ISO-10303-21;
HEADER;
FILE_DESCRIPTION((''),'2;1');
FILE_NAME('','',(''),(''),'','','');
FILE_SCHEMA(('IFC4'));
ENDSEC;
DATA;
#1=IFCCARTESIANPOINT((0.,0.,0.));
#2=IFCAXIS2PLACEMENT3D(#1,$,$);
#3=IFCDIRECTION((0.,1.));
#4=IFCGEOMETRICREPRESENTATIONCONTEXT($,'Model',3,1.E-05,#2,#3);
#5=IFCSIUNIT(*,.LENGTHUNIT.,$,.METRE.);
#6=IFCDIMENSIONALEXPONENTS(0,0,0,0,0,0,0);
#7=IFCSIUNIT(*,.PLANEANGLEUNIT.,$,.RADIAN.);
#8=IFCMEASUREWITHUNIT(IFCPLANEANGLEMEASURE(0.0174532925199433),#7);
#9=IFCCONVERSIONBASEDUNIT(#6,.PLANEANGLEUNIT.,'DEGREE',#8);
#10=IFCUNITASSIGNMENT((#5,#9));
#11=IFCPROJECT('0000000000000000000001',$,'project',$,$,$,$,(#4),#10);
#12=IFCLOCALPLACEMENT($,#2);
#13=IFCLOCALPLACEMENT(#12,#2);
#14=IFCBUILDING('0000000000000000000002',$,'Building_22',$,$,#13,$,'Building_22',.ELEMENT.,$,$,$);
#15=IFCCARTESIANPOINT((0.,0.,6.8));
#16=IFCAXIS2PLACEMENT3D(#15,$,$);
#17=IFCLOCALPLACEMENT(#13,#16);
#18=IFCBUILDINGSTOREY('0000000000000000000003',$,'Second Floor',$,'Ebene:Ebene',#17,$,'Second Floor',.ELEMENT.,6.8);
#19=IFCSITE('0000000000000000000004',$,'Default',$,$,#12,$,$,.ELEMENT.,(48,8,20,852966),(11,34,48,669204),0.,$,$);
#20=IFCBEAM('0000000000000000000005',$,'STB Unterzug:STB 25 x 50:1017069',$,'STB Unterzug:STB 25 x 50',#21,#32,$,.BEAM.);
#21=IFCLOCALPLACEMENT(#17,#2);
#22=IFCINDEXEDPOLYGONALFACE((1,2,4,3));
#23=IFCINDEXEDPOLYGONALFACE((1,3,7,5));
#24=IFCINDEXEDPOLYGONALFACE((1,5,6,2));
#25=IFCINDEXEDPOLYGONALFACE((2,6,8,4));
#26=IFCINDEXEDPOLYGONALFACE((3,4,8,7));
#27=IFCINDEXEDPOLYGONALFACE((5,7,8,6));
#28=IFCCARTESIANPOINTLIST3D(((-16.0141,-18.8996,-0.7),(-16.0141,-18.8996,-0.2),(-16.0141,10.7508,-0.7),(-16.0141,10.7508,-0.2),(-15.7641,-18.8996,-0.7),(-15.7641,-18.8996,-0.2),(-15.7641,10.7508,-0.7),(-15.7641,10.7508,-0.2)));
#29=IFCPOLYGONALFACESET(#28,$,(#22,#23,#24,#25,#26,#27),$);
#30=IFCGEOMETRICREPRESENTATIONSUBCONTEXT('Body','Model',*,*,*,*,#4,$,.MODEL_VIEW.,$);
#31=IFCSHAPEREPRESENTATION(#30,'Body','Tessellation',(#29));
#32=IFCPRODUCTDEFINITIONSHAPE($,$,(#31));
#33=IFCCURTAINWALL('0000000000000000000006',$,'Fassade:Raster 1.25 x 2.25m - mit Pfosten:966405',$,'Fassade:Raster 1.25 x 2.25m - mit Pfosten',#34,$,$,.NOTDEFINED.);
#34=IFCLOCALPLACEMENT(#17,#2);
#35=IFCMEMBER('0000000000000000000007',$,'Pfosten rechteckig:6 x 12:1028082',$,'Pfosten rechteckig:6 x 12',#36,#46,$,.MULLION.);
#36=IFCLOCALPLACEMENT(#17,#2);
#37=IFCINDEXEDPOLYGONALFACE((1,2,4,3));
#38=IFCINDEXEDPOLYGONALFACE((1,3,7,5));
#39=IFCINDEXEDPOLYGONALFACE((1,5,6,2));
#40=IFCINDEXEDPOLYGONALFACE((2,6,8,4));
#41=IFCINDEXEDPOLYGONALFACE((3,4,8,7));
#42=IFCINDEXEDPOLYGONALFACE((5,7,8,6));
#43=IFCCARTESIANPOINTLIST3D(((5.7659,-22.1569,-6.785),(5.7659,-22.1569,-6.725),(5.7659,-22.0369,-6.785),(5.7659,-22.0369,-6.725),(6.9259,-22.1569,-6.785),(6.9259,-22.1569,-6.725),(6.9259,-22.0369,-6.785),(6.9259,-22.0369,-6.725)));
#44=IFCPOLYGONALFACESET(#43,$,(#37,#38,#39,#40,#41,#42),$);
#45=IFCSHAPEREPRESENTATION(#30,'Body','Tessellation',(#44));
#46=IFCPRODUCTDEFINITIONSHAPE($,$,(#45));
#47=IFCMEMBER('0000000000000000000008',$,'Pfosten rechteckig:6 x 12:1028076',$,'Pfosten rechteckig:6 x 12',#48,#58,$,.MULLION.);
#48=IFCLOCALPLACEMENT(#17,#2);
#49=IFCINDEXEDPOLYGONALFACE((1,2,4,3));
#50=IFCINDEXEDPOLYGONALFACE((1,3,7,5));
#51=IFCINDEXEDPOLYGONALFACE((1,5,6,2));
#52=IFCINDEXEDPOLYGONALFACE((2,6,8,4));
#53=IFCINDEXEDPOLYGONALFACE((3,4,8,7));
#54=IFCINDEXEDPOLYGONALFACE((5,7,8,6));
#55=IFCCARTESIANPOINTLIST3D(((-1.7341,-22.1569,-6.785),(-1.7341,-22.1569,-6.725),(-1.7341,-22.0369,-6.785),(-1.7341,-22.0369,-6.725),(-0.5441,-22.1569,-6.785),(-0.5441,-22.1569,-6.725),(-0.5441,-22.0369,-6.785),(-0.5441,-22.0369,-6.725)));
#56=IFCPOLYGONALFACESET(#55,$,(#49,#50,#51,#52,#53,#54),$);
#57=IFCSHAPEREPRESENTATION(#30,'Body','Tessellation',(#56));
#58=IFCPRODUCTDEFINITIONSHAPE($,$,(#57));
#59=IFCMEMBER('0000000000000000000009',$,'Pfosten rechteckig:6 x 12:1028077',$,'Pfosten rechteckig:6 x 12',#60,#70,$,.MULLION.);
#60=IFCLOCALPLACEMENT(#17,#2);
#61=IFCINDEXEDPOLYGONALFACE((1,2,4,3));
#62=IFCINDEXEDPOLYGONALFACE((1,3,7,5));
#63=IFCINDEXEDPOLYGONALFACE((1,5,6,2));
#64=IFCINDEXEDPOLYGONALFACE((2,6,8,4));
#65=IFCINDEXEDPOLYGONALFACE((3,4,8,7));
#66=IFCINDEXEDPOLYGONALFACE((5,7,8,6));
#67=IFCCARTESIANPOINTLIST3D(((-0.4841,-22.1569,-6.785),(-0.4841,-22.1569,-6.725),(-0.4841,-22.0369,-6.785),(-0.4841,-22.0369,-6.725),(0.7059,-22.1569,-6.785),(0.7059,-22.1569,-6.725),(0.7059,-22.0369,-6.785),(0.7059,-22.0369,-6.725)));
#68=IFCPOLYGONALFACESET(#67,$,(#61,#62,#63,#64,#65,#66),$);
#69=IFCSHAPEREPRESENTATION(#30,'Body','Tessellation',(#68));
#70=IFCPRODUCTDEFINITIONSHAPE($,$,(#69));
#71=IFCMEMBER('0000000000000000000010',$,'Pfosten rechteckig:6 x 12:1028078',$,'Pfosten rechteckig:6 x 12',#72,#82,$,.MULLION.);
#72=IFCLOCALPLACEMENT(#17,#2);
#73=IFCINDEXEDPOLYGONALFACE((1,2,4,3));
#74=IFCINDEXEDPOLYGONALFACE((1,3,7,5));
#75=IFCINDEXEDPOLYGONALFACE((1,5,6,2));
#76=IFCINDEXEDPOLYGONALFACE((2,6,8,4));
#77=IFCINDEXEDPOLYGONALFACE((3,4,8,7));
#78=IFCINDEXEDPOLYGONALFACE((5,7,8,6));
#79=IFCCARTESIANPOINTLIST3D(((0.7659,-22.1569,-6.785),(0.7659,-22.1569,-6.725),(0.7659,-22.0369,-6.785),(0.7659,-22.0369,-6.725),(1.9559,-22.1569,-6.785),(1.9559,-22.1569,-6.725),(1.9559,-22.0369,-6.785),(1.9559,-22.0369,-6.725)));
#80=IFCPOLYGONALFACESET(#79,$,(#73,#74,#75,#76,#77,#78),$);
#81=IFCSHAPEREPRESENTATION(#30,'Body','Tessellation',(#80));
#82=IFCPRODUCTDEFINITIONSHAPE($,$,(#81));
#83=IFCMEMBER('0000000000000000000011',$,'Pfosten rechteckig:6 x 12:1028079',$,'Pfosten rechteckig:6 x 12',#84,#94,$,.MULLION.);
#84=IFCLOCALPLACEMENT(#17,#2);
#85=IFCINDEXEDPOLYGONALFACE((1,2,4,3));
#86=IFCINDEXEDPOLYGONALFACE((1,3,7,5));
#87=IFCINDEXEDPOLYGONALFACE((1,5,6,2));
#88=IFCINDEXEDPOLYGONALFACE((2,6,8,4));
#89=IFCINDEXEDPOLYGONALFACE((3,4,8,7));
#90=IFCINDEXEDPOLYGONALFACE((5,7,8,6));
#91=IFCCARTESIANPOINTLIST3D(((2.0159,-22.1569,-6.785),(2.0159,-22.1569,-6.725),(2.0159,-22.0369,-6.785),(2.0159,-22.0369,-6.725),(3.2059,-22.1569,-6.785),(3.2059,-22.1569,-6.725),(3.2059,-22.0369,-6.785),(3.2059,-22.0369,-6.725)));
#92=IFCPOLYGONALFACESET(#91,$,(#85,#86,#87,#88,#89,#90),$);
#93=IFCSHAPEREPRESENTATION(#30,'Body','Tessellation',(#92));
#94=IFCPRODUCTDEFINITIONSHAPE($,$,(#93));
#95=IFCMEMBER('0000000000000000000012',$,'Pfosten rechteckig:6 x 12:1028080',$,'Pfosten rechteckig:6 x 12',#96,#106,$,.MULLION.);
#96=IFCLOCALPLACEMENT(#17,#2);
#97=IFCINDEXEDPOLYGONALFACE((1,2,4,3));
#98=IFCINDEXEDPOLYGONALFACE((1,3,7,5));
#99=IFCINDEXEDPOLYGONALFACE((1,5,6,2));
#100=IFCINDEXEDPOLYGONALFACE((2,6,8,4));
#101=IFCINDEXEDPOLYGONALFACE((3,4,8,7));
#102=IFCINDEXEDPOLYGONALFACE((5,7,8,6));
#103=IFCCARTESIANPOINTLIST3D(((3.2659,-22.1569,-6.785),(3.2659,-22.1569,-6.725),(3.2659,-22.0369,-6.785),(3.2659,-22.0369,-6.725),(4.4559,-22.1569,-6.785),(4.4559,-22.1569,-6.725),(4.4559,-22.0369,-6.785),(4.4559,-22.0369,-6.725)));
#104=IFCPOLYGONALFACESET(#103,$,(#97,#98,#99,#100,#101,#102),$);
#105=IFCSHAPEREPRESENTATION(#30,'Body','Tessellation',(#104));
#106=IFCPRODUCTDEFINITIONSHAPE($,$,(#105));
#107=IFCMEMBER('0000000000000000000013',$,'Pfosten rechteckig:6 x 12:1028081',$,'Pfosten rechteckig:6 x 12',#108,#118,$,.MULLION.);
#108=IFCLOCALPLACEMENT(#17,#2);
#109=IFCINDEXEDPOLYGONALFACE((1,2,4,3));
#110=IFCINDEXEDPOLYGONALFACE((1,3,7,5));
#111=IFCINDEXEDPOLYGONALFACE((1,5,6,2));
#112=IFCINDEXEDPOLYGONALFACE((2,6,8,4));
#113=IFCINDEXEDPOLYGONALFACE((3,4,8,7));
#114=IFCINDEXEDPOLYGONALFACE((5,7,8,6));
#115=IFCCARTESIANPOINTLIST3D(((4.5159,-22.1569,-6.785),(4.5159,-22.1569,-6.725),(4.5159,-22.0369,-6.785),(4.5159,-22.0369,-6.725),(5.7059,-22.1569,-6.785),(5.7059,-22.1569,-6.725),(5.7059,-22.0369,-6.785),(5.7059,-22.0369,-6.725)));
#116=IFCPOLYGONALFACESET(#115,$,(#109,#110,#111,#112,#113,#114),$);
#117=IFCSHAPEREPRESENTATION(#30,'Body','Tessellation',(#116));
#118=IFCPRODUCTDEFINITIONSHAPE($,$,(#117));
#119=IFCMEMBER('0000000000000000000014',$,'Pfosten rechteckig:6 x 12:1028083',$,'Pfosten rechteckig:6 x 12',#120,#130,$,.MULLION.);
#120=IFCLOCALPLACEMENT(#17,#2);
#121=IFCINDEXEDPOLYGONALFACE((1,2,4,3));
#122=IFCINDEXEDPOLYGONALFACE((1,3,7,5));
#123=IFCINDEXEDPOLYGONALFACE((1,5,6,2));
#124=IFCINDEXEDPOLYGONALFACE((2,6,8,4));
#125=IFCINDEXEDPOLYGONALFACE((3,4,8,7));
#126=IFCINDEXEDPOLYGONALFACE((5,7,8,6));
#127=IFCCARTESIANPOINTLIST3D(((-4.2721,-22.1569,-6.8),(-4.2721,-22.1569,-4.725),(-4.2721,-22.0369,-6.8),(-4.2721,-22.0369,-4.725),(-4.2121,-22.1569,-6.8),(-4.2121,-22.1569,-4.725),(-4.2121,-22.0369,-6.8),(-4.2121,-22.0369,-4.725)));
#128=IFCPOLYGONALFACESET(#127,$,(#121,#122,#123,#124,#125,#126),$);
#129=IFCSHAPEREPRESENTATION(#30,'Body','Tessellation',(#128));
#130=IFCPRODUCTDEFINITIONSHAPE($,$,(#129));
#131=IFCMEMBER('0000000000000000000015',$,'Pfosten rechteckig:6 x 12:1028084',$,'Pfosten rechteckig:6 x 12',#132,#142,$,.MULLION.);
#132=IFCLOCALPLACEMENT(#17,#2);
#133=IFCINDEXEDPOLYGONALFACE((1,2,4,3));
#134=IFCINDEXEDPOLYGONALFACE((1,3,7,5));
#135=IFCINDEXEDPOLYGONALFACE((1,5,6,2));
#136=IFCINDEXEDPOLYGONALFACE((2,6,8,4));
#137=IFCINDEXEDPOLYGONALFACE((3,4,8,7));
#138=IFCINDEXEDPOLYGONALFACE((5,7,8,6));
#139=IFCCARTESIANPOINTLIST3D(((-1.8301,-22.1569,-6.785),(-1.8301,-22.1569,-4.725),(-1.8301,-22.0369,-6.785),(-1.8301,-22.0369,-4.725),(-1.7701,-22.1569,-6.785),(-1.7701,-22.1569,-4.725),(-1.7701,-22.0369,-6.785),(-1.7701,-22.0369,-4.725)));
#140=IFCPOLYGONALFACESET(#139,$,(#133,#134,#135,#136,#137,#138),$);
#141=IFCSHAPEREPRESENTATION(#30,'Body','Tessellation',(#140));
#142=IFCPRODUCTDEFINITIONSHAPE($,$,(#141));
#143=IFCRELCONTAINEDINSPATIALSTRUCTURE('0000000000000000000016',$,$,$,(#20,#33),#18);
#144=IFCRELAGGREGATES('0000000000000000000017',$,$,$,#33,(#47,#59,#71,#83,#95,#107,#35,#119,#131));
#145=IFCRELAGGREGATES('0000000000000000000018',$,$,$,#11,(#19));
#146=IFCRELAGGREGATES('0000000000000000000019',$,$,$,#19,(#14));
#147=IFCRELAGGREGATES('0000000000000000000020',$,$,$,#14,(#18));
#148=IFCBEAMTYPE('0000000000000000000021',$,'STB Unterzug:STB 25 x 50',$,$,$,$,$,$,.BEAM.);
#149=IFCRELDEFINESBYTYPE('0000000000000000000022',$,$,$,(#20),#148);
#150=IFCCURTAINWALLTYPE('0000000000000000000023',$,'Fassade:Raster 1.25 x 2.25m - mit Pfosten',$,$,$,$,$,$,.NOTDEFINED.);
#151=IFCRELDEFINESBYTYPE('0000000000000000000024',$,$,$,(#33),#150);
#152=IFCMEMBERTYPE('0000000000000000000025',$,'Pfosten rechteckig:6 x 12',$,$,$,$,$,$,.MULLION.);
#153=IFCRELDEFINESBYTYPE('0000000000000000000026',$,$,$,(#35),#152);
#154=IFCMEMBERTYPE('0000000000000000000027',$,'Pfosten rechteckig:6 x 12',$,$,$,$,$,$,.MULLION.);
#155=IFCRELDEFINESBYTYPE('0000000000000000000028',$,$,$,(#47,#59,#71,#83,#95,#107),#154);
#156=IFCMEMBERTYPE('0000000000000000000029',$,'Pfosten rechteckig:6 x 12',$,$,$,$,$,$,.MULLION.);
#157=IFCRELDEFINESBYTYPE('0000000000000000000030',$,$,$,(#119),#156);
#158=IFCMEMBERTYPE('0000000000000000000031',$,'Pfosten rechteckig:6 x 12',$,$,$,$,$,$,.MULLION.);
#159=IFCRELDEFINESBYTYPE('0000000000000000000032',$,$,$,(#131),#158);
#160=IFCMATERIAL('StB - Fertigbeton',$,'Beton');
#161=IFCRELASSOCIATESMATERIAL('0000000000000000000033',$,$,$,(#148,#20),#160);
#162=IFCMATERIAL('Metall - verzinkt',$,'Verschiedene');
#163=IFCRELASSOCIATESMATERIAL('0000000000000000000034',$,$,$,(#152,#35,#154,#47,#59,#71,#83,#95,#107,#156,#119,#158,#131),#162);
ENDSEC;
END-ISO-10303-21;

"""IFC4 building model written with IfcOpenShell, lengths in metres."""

from ifc_helpers import new_model, entity, si_unit, converted_unit, direction, frame, origin, place, context, subcontext, project, spatial, indexed_curve, outline, extrude, source, transform, mapped, material, type_object, type_shapes, element, aggregate, save


model = new_model("IFC4")

# Units and contexts
model_context = context("Model", 3, precision=1e-05, world=origin(), true_north=direction((0.0, 1.0)))
body_context = subcontext(model_context, "Body", "Model", "MODEL_VIEW")
ifc_project = project(units=[si_unit("LENGTHUNIT", "METRE"), converted_unit("PLANEANGLEUNIT", "DEGREE", entity("IfcPlaneAngleMeasure", 0.0174532925199433), si_unit("PLANEANGLEUNIT", "RADIAN"), dimensions=[0, 0, 0, 0, 0, 0, 0])], contexts=[model_context])

# Site, building, storey
site_placement = place(None, origin())
site = spatial("IfcSite", under=ifc_project, at=site_placement, Name="Default", CompositionType="ELEMENT", RefLatitude=(48, 8, 20, 852966), RefLongitude=(11, 34, 48, 669204), RefElevation=0.0)
building_placement = place(site_placement, origin())
building = spatial("IfcBuilding", under=site, at=building_placement, Name="Building_22", LongName="Building_22", CompositionType="ELEMENT")
storey_placement = place(building_placement, frame((0.0, 0.0, 6.8)))
storey = spatial("IfcBuildingStorey", under=building, at=storey_placement, Name="Second Floor", ObjectType="Ebene:Ebene", LongName="Second Floor", CompositionType="ELEMENT", Elevation=6.8)

# Beam
ifc_material_1 = material(Name="StB - Fertigbeton", Category="Beton")
beam_type_1 = type_object("IfcBeamType", Name="STB Unterzug:STB 25 x 50", PredefinedType="BEAM", material=ifc_material_1)
shared_shape_1 = source(origin(), body_context, "Body", "SweptSolid", [
    extrude(outline(indexed_curve([(-14.8252, -0.125), (14.8252, -0.125), (14.8252, 0.125), (-14.8252, 0.125), (-14.8252, -0.125)], self_intersect=False)), frame((0.0, 0.0, -0.25), z_axis=(0.0, 0.0, 1.0), x_axis=(-1.0, 0.0, 0.0)), (0.0, 0.0, 1.0), 0.5),
])
type_shapes(beam_type_1, [shared_shape_1])
beam_1_placement = place(storey_placement, frame((-15.8891, -4.0744, -0.45), z_axis=(0.0, 0.0, 1.0), x_axis=(0.0, -1.0, 0.0)))
element("IfcBeam", 1, at=beam_1_placement, inside=storey, type_object=beam_type_1, material=ifc_material_1, Name="STB Unterzug:STB 25 x 50:1017069", ObjectType="STB Unterzug:STB 25 x 50", PredefinedType="BEAM", context=body_context, shape_type="MappedRepresentation", body=[
    mapped(shared_shape_1, transform((0.0, 0.0, 0.0), scale=1.0)),
])

# Curtain wall, members
curtain_wall_type_1 = type_object("IfcCurtainWallType", Name="Fassade:Raster 1.25 x 2.25m - mit Pfosten", PredefinedType="NOTDEFINED")
curtain_wall_1_placement = place(storey_placement, frame((0.0, 0.0, -6.8)))
curtain_wall_1 = element("IfcCurtainWall", 2, at=curtain_wall_1_placement, inside=storey, type_object=curtain_wall_type_1, Name="Fassade:Raster 1.25 x 2.25m - mit Pfosten:966405", ObjectType="Fassade:Raster 1.25 x 2.25m - mit Pfosten", PredefinedType="NOTDEFINED")
ifc_material_2 = material(Name="Metall - verzinkt", Category="Verschiedene")
member_type_1 = type_object("IfcMemberType", Name="Pfosten rechteckig:6 x 12", PredefinedType="MULLION", material=ifc_material_2)
shared_shape_2 = source(origin(), body_context, "Body", "SweptSolid", [
    extrude(outline(indexed_curve([(-0.03, -0.06), (0.03, -0.06), (0.03, 0.06), (-0.03, 0.06), (-0.03, -0.06)], self_intersect=False)), frame((-0.03, 0.0, -1.16), z_axis=(0.0, 0.0, 1.0), x_axis=(-1.0, 0.0, 0.0)), (0.0, 0.0, 1.0), 1.16),
])
type_shapes(member_type_1, [shared_shape_2])
member_1_placement = place(curtain_wall_1_placement, frame((5.7659, -22.0969, 0.015), z_axis=(-1.0, 0.0, 0.0), x_axis=(0.0, 0.0, -1.0)))
member_1 = element("IfcMember", 3, at=member_1_placement, type_object=member_type_1, material=ifc_material_2, Name="Pfosten rechteckig:6 x 12:1028082", ObjectType="Pfosten rechteckig:6 x 12", PredefinedType="MULLION", context=body_context, shape_type="MappedRepresentation", body=[
    mapped(shared_shape_2, transform((0.0, 0.0, 0.0), scale=1.0)),
])
member_type_2 = type_object("IfcMemberType", Name="Pfosten rechteckig:6 x 12", PredefinedType="MULLION", material=ifc_material_2)
shared_shape_3 = source(origin(), body_context, "Body", "SweptSolid", [
    extrude(outline(indexed_curve([(-0.03, -0.06), (0.03, -0.06), (0.03, 0.06), (-0.03, 0.06), (-0.03, -0.06)], self_intersect=False)), frame((-0.03, 0.0, -1.19), z_axis=(0.0, 0.0, 1.0), x_axis=(-1.0, 0.0, 0.0)), (0.0, 0.0, 1.0), 1.19),
])
type_shapes(member_type_2, [shared_shape_3])
member_2_placement = place(curtain_wall_1_placement, frame((-1.7341, -22.0969, 0.015), z_axis=(-1.0, 0.0, 0.0), x_axis=(0.0, 0.0, -1.0)))
member_2 = element("IfcMember", 4, at=member_2_placement, type_object=member_type_2, material=ifc_material_2, Name="Pfosten rechteckig:6 x 12:1028076", ObjectType="Pfosten rechteckig:6 x 12", PredefinedType="MULLION", context=body_context, shape_type="MappedRepresentation", body=[
    mapped(shared_shape_3, transform((0.0, 0.0, 0.0), scale=1.0)),
])
member_3_placement = place(curtain_wall_1_placement, frame((-0.4841, -22.0969, 0.015), z_axis=(-1.0, 0.0, 0.0), x_axis=(0.0, 0.0, -1.0)))
member_3 = element("IfcMember", 5, at=member_3_placement, type_object=member_type_2, material=ifc_material_2, Name="Pfosten rechteckig:6 x 12:1028077", ObjectType="Pfosten rechteckig:6 x 12", PredefinedType="MULLION", context=body_context, shape_type="MappedRepresentation", body=[
    mapped(shared_shape_3, transform((0.0, 0.0, 0.0), scale=1.0)),
])
member_4_placement = place(curtain_wall_1_placement, frame((0.7659, -22.0969, 0.015), z_axis=(-1.0, 0.0, 0.0), x_axis=(0.0, 0.0, -1.0)))
member_4 = element("IfcMember", 6, at=member_4_placement, type_object=member_type_2, material=ifc_material_2, Name="Pfosten rechteckig:6 x 12:1028078", ObjectType="Pfosten rechteckig:6 x 12", PredefinedType="MULLION", context=body_context, shape_type="MappedRepresentation", body=[
    mapped(shared_shape_3, transform((0.0, 0.0, 0.0), scale=1.0)),
])
member_5_placement = place(curtain_wall_1_placement, frame((2.0159, -22.0969, 0.015), z_axis=(-1.0, 0.0, 0.0), x_axis=(0.0, 0.0, -1.0)))
member_5 = element("IfcMember", 7, at=member_5_placement, type_object=member_type_2, material=ifc_material_2, Name="Pfosten rechteckig:6 x 12:1028079", ObjectType="Pfosten rechteckig:6 x 12", PredefinedType="MULLION", context=body_context, shape_type="MappedRepresentation", body=[
    mapped(shared_shape_3, transform((0.0, 0.0, 0.0), scale=1.0)),
])
member_6_placement = place(curtain_wall_1_placement, frame((3.2659, -22.0969, 0.015), z_axis=(-1.0, 0.0, 0.0), x_axis=(0.0, 0.0, -1.0)))
member_6 = element("IfcMember", 8, at=member_6_placement, type_object=member_type_2, material=ifc_material_2, Name="Pfosten rechteckig:6 x 12:1028080", ObjectType="Pfosten rechteckig:6 x 12", PredefinedType="MULLION", context=body_context, shape_type="MappedRepresentation", body=[
    mapped(shared_shape_3, transform((0.0, 0.0, 0.0), scale=1.0)),
])
member_7_placement = place(curtain_wall_1_placement, frame((4.5159, -22.0969, 0.015), z_axis=(-1.0, 0.0, 0.0), x_axis=(0.0, 0.0, -1.0)))
member_7 = element("IfcMember", 9, at=member_7_placement, type_object=member_type_2, material=ifc_material_2, Name="Pfosten rechteckig:6 x 12:1028081", ObjectType="Pfosten rechteckig:6 x 12", PredefinedType="MULLION", context=body_context, shape_type="MappedRepresentation", body=[
    mapped(shared_shape_3, transform((0.0, 0.0, 0.0), scale=1.0)),
])
member_type_3 = type_object("IfcMemberType", Name="Pfosten rechteckig:6 x 12", PredefinedType="MULLION", material=ifc_material_2)
shared_shape_4 = source(origin(), body_context, "Body", "SweptSolid", [
    extrude(outline(indexed_curve([(-0.03, -0.06), (0.03, -0.06), (0.03, 0.06), (-0.03, 0.06), (-0.03, -0.06)], self_intersect=False)), frame((-0.03, 0.0, -2.075), z_axis=(0.0, 0.0, 1.0), x_axis=(-1.0, 0.0, 0.0)), (0.0, 0.0, 1.0), 2.075),
])
type_shapes(member_type_3, [shared_shape_4])
member_8_placement = place(curtain_wall_1_placement, frame((-4.2121, -22.0969, 0.0), z_axis=(0.0, 0.0, -1.0), x_axis=(1.0, 0.0, 0.0)))
member_8 = element("IfcMember", 10, at=member_8_placement, type_object=member_type_3, material=ifc_material_2, Name="Pfosten rechteckig:6 x 12:1028083", ObjectType="Pfosten rechteckig:6 x 12", PredefinedType="MULLION", context=body_context, shape_type="MappedRepresentation", body=[
    mapped(shared_shape_4, transform((0.0, 0.0, 0.0), scale=1.0)),
])
member_type_4 = type_object("IfcMemberType", Name="Pfosten rechteckig:6 x 12", PredefinedType="MULLION", material=ifc_material_2)
shared_shape_5 = source(origin(), body_context, "Body", "SweptSolid", [
    extrude(outline(indexed_curve([(-0.03, -0.06), (0.03, -0.06), (0.03, 0.06), (-0.03, 0.06), (-0.03, -0.06)], self_intersect=False)), frame((-0.03, 0.0, -2.06), z_axis=(0.0, 0.0, 1.0), x_axis=(-1.0, 0.0, 0.0)), (0.0, 0.0, 1.0), 2.06),
])
type_shapes(member_type_4, [shared_shape_5])
member_9_placement = place(curtain_wall_1_placement, frame((-1.8301, -22.0969, 2.075), z_axis=(0.0, 0.0, 1.0), x_axis=(-1.0, 0.0, 0.0)))
member_9 = element("IfcMember", 11, at=member_9_placement, type_object=member_type_4, material=ifc_material_2, Name="Pfosten rechteckig:6 x 12:1028084", ObjectType="Pfosten rechteckig:6 x 12", PredefinedType="MULLION", context=body_context, shape_type="MappedRepresentation", body=[
    mapped(shared_shape_5, transform((0.0, 0.0, 0.0), scale=1.0)),
])
aggregate(curtain_wall_1, [member_2, member_3, member_4, member_5, member_6, member_7, member_1, member_8, member_9])

save(model, "model.ifc")
